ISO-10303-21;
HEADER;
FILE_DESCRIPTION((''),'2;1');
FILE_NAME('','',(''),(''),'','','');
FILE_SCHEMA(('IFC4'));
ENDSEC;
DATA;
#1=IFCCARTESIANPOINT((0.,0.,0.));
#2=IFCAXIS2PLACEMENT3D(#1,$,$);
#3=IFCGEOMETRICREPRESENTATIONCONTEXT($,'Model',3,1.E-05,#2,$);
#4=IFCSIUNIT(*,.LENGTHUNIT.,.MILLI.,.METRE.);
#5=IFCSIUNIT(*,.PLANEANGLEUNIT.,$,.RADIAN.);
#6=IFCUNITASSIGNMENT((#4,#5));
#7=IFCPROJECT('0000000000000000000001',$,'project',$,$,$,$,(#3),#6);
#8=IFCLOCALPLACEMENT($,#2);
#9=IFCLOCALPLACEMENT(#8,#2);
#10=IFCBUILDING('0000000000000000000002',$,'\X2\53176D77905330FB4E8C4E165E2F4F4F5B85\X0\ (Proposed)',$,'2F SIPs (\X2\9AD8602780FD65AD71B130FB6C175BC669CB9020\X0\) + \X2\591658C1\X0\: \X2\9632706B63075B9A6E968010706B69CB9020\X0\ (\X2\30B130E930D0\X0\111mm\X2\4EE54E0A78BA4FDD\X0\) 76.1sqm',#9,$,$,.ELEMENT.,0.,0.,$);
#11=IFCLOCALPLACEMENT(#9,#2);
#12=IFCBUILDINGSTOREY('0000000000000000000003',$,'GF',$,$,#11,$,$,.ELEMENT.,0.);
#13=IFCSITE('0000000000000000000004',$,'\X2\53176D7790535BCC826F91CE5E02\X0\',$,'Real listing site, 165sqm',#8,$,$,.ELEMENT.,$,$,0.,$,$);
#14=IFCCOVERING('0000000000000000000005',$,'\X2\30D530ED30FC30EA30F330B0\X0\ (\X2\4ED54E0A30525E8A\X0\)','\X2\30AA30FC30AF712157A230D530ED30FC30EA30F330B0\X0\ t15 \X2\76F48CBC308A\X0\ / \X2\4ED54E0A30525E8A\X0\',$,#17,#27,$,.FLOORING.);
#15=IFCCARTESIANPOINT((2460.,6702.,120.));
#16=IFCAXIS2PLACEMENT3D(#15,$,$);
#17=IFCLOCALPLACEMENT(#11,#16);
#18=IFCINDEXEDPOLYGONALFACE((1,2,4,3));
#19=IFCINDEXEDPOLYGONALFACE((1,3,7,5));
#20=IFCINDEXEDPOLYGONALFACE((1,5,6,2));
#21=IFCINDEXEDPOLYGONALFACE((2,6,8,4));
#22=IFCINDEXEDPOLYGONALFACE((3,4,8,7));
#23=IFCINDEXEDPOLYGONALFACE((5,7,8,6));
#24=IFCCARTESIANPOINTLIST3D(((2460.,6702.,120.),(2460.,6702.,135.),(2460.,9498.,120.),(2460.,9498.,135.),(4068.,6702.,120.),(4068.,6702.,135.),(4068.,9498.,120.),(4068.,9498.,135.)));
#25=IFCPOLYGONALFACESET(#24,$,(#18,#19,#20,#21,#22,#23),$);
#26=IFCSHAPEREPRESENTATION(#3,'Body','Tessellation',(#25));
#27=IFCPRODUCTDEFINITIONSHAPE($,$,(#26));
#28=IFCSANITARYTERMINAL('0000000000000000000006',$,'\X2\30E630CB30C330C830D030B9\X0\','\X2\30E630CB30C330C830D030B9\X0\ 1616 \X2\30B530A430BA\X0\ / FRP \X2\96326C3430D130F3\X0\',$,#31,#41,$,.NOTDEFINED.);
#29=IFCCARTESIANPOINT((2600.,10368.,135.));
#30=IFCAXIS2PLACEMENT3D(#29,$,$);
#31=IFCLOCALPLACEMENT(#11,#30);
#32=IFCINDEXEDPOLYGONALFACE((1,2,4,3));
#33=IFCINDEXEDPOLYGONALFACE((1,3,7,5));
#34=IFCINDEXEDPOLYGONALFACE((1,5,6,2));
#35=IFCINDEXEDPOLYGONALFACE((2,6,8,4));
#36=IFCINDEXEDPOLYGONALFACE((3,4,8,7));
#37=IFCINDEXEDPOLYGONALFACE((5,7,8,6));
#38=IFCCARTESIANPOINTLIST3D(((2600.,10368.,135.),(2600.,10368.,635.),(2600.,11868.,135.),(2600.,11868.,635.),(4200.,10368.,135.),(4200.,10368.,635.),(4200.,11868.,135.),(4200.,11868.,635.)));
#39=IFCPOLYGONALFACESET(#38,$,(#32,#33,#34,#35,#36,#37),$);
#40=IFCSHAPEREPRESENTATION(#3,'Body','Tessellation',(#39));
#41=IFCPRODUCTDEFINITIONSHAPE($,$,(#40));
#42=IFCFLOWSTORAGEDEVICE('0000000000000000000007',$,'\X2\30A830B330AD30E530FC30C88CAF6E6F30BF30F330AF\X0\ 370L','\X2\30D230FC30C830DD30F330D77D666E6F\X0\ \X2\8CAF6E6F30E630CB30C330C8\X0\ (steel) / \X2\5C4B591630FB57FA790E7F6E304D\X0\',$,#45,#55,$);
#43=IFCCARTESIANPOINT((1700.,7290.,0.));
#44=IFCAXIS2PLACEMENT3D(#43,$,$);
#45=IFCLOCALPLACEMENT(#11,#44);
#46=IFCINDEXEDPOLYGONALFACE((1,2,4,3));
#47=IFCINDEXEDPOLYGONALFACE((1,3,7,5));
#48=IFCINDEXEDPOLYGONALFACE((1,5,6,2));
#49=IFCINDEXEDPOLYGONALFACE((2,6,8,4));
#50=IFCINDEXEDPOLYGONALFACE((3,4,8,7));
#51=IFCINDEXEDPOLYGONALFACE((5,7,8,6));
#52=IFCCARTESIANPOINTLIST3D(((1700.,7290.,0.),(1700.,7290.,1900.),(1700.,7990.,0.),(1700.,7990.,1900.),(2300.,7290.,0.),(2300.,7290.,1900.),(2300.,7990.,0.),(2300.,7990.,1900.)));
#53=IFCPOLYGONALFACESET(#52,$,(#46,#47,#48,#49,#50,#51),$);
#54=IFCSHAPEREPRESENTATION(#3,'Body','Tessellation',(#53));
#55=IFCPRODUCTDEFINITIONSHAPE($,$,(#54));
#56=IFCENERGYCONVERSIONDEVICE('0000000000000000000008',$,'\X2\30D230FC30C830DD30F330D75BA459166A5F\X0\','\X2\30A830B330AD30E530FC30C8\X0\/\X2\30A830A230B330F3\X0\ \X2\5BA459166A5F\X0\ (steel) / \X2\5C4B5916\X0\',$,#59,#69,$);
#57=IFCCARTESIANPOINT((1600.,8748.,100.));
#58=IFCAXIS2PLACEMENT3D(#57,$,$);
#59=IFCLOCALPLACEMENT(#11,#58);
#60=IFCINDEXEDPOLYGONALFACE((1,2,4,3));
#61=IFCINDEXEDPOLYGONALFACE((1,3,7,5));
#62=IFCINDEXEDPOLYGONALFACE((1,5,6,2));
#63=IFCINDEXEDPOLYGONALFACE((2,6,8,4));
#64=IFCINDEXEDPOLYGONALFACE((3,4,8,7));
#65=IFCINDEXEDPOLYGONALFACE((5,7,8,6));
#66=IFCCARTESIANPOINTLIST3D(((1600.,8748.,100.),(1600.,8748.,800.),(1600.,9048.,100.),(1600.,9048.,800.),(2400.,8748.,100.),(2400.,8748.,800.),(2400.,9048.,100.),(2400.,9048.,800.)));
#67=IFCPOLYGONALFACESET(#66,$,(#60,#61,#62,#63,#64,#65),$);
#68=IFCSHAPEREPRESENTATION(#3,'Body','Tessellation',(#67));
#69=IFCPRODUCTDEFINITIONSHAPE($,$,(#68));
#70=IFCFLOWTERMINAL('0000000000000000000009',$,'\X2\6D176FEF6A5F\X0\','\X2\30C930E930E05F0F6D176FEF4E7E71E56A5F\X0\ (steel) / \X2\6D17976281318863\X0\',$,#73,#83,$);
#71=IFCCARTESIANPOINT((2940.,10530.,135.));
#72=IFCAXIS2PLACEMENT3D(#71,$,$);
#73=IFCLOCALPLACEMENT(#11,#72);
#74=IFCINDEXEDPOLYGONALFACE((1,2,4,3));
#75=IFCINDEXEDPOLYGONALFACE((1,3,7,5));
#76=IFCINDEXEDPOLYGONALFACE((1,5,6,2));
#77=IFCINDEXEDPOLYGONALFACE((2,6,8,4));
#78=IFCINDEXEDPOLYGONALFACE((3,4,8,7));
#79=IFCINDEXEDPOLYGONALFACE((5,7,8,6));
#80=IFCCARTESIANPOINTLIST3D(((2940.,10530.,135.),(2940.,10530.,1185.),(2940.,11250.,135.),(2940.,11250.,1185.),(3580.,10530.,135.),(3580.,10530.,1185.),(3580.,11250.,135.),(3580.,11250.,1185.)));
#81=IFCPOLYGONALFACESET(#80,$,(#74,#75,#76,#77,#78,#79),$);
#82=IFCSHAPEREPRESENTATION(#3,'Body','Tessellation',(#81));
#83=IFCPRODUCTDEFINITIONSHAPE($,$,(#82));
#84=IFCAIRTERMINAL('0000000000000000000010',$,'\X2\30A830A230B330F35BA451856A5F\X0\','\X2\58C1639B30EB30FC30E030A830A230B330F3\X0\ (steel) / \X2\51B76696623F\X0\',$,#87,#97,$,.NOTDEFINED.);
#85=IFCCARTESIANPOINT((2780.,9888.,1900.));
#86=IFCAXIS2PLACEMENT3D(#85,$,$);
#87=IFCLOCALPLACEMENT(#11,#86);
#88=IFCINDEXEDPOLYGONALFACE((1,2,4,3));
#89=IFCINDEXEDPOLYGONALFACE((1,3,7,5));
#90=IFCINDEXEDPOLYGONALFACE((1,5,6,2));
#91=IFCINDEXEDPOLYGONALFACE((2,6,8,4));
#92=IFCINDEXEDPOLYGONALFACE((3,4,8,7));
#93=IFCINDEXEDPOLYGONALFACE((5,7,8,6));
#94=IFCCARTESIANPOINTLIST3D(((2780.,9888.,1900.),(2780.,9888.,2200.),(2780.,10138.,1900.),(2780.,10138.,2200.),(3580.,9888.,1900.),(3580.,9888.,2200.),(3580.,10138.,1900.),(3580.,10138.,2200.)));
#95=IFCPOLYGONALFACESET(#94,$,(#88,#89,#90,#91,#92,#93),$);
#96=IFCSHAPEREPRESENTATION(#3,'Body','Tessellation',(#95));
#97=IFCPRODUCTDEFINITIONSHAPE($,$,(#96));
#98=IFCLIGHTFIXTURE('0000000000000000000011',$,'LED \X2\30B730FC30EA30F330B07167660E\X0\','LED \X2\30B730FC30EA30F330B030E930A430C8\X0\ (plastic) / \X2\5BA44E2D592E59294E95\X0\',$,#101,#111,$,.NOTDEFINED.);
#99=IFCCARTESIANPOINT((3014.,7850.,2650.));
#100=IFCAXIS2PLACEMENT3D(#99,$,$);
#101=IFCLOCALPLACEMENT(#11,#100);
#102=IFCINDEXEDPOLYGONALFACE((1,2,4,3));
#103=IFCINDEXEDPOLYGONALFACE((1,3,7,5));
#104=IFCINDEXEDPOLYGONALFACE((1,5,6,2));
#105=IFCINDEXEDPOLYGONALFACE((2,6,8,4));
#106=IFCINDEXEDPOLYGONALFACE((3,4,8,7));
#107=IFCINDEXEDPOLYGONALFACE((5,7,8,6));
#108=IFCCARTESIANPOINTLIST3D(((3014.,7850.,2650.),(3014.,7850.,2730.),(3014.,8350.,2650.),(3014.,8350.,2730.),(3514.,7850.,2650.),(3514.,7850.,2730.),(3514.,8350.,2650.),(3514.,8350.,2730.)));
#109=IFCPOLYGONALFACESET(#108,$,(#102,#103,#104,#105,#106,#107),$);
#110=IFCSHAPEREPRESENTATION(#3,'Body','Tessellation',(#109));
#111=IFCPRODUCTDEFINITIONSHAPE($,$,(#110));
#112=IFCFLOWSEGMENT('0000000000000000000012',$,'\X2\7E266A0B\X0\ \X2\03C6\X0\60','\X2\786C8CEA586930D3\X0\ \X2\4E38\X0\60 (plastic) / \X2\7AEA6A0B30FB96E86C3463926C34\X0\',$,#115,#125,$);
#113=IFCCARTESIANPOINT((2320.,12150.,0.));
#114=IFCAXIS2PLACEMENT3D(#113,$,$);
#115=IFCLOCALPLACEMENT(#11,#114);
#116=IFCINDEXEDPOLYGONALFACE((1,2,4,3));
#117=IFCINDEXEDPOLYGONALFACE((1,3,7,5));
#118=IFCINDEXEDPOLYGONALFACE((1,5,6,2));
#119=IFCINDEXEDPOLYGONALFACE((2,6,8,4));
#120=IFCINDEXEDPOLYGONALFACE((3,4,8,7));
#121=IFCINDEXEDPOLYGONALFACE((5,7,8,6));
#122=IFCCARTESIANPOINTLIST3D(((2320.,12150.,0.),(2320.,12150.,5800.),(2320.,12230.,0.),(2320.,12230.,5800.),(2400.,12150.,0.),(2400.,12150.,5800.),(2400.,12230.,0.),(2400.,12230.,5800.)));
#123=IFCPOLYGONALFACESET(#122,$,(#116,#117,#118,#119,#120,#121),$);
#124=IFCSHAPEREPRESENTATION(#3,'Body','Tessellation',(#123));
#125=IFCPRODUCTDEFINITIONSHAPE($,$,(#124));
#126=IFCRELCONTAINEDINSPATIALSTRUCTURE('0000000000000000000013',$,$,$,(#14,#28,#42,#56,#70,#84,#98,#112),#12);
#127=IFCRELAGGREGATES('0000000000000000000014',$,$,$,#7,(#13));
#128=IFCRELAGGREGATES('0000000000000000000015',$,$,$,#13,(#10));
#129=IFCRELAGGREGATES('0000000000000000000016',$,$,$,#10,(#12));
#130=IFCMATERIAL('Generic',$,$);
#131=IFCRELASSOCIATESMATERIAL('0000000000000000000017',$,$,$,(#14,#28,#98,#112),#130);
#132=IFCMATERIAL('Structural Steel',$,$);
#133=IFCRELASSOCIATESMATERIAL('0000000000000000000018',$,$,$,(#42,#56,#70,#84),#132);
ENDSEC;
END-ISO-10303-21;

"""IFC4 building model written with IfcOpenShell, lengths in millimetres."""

from ifc_helpers import new_model, si_unit, frame, frame_2d, origin, place, context, project, spatial, rectangle, extrude, material, element, save


model = new_model("IFC4")

# Units and contexts
model_context = context("Model", 3, precision=1e-05, world=origin())
ifc_project = project(units=[si_unit("LENGTHUNIT", "METRE", prefix="MILLI"), si_unit("PLANEANGLEUNIT", "RADIAN")], contexts=[model_context])

# Site, building, storey
site_placement = place(None, origin())
site = spatial("IfcSite", under=ifc_project, at=site_placement, Name="北海道富良野市", ObjectType="Real listing site, 165sqm", CompositionType="ELEMENT", RefElevation=0.0)
building_placement = place(site_placement, origin())
building = spatial("IfcBuilding", under=site, at=building_placement, Name="北海道・二世帯住宅 (Proposed)", ObjectType="2F SIPs (高性能断熱・気密構造) + 外壁: 防火指定準耐火構造 (ケラバ111mm以上確保) 76.1sqm", CompositionType="ELEMENT", ElevationOfRefHeight=0.0, ElevationOfTerrain=0.0)
storey_placement = place(building_placement, origin())
storey = spatial("IfcBuildingStorey", under=building, at=storey_placement, Name="GF", CompositionType="ELEMENT", Elevation=0.0)

# Covering
ifc_material_1 = material(Name="Generic")
covering_1_placement = place(storey_placement, frame((2460.0, 6702.0, 120.0)))
element("IfcCovering", 1, at=covering_1_placement, inside=storey, material=ifc_material_1, Name="フローリング (仕上げ床)", Description="オーク無垢フローリング t15 直貼り / 仕上げ床", PredefinedType="FLOORING", context=model_context, shape_type="SweptSolid", body=[
    extrude(rectangle(XDim=1608.0, YDim=2796.0, at=frame_2d((804.0, 1398.0))), frame((2460.0, 6702.0, 120.0)), (0.0, 0.0, 1.0), 15.0),
])

# Sanitary terminal
sanitary_terminal_placement = place(storey_placement, frame((2600.0, 10368.0, 135.0)))
element("IfcSanitaryTerminal", 2, at=sanitary_terminal_placement, inside=storey, material=ifc_material_1, Name="ユニットバス", Description="ユニットバス 1616 サイズ / FRP 防水パン", PredefinedType="NOTDEFINED", context=model_context, shape_type="SweptSolid", body=[
    extrude(rectangle(XDim=1600.0, YDim=1500.0, at=frame_2d((800.0, 750.0))), frame((2600.0, 10368.0, 135.0)), (0.0, 0.0, 1.0), 500.0),
])

# Flow storage device
ifc_material_2 = material(Name="Structural Steel")
flow_storage_device_placement = place(storey_placement, frame((1700.0, 7290.0, 0.0)))
element("IfcFlowStorageDevice", 3, at=flow_storage_device_placement, inside=storey, material=ifc_material_2, Name="エコキュート貯湯タンク 370L", Description="ヒートポンプ給湯 貯湯ユニット (steel) / 屋外・基礎置き", context=model_context, shape_type="SweptSolid", body=[
    extrude(rectangle(XDim=600.0, YDim=700.0, at=frame_2d((300.0, 350.0))), frame((1700.0, 7290.0, 0.0)), (0.0, 0.0, 1.0), 1900.0),
])

# Energy conversion device
energy_conversion_device_placement = place(storey_placement, frame((1600.0, 8748.0, 100.0)))
element("IfcEnergyConversionDevice", 4, at=energy_conversion_device_placement, inside=storey, material=ifc_material_2, Name="ヒートポンプ室外機", Description="エコキュート/エアコン 室外機 (steel) / 屋外", context=model_context, shape_type="SweptSolid", body=[
    extrude(rectangle(XDim=800.0, YDim=300.0, at=frame_2d((400.0, 150.0))), frame((1600.0, 8748.0, 100.0)), (0.0, 0.0, 1.0), 700.0),
])

# Flow terminal
flow_terminal_placement = place(storey_placement, frame((2940.0, 10530.0, 135.0)))
element("IfcFlowTerminal", 5, at=flow_terminal_placement, inside=storey, material=ifc_material_2, Name="洗濯機", Description="ドラム式洗濯乾燥機 (steel) / 洗面脱衣", context=model_context, shape_type="SweptSolid", body=[
    extrude(rectangle(XDim=640.0, YDim=720.0, at=frame_2d((320.0, 360.0))), frame((2940.0, 10530.0, 135.0)), (0.0, 0.0, 1.0), 1050.0),
])

# Air terminal
air_terminal_placement = place(storey_placement, frame((2780.0, 9888.0, 1900.0)))
element("IfcAirTerminal", 6, at=air_terminal_placement, inside=storey, material=ifc_material_2, Name="エアコン室内機", Description="壁掛ルームエアコン (steel) / 冷暖房", PredefinedType="NOTDEFINED", context=model_context, shape_type="SweptSolid", body=[
    extrude(rectangle(XDim=800.0, YDim=250.0, at=frame_2d((400.0, 125.0))), frame((2780.0, 9888.0, 1900.0)), (0.0, 0.0, 1.0), 300.0),
])

# Light fixture
light_fixture_placement = place(storey_placement, frame((3014.0, 7850.0, 2650.0)))
element("IfcLightFixture", 7, at=light_fixture_placement, inside=storey, material=ifc_material_1, Name="LED シーリング照明", Description="LED シーリングライト (plastic) / 室中央天井", PredefinedType="NOTDEFINED", context=model_context, shape_type="SweptSolid", body=[
    extrude(rectangle(XDim=500.0, YDim=500.0, at=frame_2d((250.0, 250.0))), frame((3014.0, 7850.0, 2650.0)), (0.0, 0.0, 1.0), 80.0),
])

# Flow segment
flow_segment_placement = place(storey_placement, frame((2320.0, 12150.0, 0.0)))
element("IfcFlowSegment", 8, at=flow_segment_placement, inside=storey, material=ifc_material_1, Name="縦樋 φ60", Description="硬質塩ビ 丸60 (plastic) / 竪樋・雨水排水", context=model_context, shape_type="SweptSolid", body=[
    extrude(rectangle(XDim=80.0, YDim=80.0, at=frame_2d((40.0, 40.0))), frame((2320.0, 12150.0, 0.0)), (0.0, 0.0, 1.0), 5800.0),
])

save(model, "model.ifc")
